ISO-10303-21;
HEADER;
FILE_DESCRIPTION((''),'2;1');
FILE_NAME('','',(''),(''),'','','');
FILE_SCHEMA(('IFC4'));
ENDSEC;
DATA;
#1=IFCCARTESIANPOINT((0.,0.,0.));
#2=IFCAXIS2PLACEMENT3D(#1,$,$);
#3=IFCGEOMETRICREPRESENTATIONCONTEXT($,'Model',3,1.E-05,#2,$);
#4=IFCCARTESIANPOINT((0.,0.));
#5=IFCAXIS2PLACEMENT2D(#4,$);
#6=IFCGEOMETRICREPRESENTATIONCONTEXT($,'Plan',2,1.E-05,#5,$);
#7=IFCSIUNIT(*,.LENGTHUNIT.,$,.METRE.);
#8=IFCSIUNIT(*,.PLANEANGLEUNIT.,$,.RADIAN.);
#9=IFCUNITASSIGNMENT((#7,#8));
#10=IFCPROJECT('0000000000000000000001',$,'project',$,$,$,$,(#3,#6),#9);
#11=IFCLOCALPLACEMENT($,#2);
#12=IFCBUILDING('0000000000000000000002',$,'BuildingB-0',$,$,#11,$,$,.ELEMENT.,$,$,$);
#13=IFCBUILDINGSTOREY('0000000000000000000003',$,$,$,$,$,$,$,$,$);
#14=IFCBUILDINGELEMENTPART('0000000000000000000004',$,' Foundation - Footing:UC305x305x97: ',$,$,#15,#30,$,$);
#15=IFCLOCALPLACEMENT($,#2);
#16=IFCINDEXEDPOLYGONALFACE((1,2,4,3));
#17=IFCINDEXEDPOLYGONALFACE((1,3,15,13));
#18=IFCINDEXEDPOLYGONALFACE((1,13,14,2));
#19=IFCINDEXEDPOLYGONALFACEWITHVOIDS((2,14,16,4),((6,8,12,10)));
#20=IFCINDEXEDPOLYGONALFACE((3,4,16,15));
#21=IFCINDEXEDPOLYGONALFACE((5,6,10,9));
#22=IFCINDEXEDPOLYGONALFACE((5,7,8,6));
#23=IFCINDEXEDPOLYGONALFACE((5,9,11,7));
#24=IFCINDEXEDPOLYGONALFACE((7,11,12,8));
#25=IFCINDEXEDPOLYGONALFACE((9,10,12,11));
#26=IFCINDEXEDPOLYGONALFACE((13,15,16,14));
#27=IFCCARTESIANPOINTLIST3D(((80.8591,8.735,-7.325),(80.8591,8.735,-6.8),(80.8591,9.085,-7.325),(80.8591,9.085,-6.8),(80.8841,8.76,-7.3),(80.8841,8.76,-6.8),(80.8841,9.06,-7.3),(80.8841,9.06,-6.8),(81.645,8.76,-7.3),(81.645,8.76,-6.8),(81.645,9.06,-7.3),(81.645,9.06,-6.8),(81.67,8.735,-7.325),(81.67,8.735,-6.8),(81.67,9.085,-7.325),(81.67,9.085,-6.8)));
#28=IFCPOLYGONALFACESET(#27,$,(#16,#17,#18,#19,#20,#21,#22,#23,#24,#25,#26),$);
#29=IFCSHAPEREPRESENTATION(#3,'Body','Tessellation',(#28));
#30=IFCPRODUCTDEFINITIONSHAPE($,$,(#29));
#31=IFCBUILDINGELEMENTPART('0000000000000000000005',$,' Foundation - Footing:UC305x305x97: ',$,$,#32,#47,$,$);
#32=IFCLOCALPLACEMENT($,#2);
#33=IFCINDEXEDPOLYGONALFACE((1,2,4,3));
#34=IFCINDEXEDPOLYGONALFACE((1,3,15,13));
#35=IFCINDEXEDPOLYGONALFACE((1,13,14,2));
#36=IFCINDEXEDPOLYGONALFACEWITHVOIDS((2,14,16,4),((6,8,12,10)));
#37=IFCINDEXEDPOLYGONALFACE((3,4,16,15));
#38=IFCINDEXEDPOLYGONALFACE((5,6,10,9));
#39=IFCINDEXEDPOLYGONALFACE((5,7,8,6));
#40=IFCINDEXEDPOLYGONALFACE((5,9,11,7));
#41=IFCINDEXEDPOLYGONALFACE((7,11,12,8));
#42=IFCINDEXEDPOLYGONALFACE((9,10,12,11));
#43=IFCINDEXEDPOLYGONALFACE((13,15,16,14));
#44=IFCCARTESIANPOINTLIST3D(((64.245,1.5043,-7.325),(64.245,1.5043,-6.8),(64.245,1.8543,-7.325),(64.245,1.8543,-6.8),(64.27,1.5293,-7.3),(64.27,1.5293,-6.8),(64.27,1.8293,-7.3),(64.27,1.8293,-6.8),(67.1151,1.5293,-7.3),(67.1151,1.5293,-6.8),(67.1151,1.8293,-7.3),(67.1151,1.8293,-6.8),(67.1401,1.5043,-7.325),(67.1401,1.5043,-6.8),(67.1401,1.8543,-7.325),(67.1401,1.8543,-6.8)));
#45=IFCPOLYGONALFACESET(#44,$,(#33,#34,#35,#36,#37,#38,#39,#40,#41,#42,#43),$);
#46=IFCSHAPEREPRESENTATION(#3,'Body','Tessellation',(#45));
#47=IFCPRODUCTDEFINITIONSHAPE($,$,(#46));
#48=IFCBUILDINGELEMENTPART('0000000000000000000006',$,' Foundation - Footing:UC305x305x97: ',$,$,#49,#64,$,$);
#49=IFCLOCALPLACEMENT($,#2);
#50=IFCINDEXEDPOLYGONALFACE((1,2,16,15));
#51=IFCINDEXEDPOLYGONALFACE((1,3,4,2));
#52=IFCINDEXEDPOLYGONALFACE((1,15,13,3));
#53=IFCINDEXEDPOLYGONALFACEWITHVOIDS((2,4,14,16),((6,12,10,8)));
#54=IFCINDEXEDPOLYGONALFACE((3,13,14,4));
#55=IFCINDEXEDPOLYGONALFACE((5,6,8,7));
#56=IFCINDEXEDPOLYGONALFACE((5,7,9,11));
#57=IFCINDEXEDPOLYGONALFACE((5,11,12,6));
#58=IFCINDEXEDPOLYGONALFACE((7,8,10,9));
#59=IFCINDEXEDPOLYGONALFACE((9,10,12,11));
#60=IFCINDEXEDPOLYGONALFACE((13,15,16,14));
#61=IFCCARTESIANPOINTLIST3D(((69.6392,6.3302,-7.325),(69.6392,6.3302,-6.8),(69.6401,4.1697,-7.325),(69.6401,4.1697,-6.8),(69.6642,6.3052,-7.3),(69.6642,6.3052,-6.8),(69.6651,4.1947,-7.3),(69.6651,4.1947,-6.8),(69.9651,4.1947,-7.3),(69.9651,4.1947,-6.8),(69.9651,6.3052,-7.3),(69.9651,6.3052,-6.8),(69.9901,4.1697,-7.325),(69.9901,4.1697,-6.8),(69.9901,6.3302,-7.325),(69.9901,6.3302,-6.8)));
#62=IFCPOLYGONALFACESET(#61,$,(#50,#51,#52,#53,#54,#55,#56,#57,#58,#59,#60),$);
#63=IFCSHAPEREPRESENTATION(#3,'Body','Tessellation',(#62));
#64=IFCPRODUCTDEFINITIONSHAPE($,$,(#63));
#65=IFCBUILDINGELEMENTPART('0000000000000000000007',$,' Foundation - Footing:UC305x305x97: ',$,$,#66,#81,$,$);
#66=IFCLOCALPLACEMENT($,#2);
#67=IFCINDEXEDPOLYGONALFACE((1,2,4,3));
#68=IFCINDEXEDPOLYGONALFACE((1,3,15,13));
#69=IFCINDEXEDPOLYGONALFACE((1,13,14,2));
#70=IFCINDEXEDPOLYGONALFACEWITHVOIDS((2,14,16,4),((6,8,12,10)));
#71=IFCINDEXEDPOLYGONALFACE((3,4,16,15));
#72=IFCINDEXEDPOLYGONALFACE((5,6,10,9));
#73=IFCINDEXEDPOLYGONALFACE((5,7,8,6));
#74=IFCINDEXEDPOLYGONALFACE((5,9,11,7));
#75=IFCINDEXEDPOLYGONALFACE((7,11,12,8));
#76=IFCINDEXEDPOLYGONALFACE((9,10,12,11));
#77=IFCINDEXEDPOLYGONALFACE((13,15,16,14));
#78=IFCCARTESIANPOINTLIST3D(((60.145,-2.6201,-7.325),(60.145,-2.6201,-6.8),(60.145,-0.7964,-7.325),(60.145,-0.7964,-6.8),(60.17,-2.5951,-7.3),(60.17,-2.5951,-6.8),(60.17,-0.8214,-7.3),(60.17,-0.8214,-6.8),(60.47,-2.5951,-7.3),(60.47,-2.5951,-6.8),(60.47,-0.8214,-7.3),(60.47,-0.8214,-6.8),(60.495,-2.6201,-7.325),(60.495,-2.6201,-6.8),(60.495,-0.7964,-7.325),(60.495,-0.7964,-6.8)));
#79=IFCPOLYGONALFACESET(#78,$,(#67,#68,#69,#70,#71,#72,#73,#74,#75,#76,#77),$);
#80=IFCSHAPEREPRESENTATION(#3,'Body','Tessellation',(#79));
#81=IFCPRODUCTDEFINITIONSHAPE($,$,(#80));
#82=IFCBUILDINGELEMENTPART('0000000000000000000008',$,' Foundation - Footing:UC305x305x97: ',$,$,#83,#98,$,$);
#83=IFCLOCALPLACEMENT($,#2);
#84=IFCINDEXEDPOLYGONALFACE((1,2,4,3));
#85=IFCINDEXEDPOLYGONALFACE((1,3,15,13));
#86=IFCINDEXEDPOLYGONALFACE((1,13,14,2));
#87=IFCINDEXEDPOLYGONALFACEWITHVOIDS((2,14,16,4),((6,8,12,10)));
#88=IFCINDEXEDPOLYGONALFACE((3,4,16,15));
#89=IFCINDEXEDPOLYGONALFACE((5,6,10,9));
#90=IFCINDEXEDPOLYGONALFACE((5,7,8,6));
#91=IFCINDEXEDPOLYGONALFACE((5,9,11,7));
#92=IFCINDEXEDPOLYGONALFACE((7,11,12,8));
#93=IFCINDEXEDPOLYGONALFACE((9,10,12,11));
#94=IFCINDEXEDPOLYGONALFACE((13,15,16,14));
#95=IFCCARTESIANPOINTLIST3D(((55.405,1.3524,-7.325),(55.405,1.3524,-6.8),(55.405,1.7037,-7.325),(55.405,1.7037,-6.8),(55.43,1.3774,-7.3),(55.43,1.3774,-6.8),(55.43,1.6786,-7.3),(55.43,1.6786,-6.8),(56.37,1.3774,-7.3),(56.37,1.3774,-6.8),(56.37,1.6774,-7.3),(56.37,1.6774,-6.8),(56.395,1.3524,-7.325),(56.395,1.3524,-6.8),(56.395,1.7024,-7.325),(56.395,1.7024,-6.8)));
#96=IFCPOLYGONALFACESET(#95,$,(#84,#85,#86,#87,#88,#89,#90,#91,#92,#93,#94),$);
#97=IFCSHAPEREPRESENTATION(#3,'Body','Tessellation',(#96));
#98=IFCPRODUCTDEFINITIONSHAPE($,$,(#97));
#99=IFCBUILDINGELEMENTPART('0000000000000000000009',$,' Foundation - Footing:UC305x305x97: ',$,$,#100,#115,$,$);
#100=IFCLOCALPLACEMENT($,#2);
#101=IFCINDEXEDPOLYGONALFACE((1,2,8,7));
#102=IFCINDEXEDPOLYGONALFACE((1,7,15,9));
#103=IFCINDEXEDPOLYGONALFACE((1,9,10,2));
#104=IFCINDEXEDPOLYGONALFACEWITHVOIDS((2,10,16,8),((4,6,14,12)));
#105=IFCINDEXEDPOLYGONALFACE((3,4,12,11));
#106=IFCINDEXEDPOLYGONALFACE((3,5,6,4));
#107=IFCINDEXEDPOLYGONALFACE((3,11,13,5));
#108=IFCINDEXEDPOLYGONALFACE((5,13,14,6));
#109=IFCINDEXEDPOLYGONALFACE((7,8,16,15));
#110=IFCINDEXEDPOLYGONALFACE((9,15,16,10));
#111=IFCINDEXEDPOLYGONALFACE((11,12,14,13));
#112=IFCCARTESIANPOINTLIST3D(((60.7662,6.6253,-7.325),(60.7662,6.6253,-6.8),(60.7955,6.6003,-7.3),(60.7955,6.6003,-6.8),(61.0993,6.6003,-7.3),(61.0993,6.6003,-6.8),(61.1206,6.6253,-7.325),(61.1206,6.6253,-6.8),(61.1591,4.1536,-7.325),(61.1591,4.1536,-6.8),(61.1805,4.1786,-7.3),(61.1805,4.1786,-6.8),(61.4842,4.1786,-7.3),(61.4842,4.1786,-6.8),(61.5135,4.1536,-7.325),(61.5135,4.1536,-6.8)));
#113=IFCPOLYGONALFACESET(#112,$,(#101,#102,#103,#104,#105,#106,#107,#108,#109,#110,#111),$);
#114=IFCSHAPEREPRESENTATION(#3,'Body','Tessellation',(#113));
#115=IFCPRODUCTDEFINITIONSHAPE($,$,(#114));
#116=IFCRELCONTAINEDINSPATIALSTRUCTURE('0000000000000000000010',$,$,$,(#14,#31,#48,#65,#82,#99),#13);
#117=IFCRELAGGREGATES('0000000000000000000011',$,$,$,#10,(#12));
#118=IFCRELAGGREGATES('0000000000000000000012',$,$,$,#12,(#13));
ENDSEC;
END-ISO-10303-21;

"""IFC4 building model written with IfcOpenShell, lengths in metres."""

from ifc_helpers import new_model, si_unit, origin, origin_2d, place, context, project, spatial, polyline, outline, extrude, element, save


model = new_model("IFC4")

# Units and contexts
model_context = context("Model", 3, precision=1e-05, world=origin())
plan_context = context("Plan", 2, precision=1e-05, world=origin_2d())
ifc_project = project(units=[si_unit("LENGTHUNIT", "METRE"), si_unit("PLANEANGLEUNIT", "RADIAN")], contexts=[model_context, plan_context])

# Building, storey
building_placement = place(None, origin())
building = spatial("IfcBuilding", under=ifc_project, at=building_placement, Name="BuildingB-0", CompositionType="ELEMENT")
storey = spatial("IfcBuildingStorey", under=building)

# Building element parts, openings
building_element_part_1 = element("IfcBuildingElementPart", 1, inside=storey, Name=" Foundation - Footing:UC305x305x97: ", context=model_context, shape_type="SweptSolid", body=[
    extrude(outline(polyline([(81.67, 8.735, -7.325), (80.8591, 8.735, -7.325), (80.8591, 9.085, -7.325), (81.67, 9.085, -7.325), (81.67, 8.735, -7.325)])), None, (0.0, 0.0, 1.0), 0.525),
])
element("IfcOpeningElement", 2, inside=storey, cuts=building_element_part_1, context=model_context, shape_type="SweptSolid", body=[
    extrude(outline(polyline([(81.645, 8.76, -7.3), (80.8841, 8.76, -7.3), (80.8841, 9.06, -7.3), (81.645, 9.06, -7.3), (81.645, 8.76, -7.3)])), None, (0.0, 0.0, 1.0), 0.5),
])
building_element_part_2 = element("IfcBuildingElementPart", 3, inside=storey, Name=" Foundation - Footing:UC305x305x97: ", context=model_context, shape_type="SweptSolid", body=[
    extrude(outline(polyline([(67.1401, 1.5043, -7.325), (67.1401, 1.8543, -7.325), (64.245, 1.8543, -7.325), (64.245, 1.5043, -7.325), (67.1401, 1.5043, -7.325)])), None, (0.0, 0.0, 1.0), 0.525),
])
element("IfcOpeningElement", 4, inside=storey, cuts=building_element_part_2, context=model_context, shape_type="SweptSolid", body=[
    extrude(outline(polyline([(67.1151, 1.5293, -7.3), (67.1151, 1.8293, -7.3), (64.27, 1.8293, -7.3), (64.27, 1.5293, -7.3), (67.1151, 1.5293, -7.3)])), None, (0.0, 0.0, 1.0), 0.5),
])
building_element_part_3 = element("IfcBuildingElementPart", 5, inside=storey, Name=" Foundation - Footing:UC305x305x97: ", context=model_context, shape_type="SweptSolid", body=[
    extrude(outline(polyline([(69.9901, 4.1697, -7.325), (69.6401, 4.1697, -7.325), (69.6392, 6.3302, -7.325), (69.9901, 6.3302, -7.325), (69.9901, 4.1697, -7.325)])), None, (0.0, 0.0, 1.0), 0.525),
])
element("IfcOpeningElement", 6, inside=storey, cuts=building_element_part_3, context=model_context, shape_type="SweptSolid", body=[
    extrude(outline(polyline([(69.9651, 4.1947, -7.3), (69.6651, 4.1947, -7.3), (69.6642, 6.3052, -7.3), (69.9651, 6.3052, -7.3), (69.9651, 4.1947, -7.3)])), None, (0.0, 0.0, 1.0), 0.5),
])
building_element_part_4 = element("IfcBuildingElementPart", 7, inside=storey, Name=" Foundation - Footing:UC305x305x97: ", context=model_context, shape_type="SweptSolid", body=[
    extrude(outline(polyline([(60.495, -2.6201, -7.325), (60.145, -2.6201, -7.325), (60.145, -0.7964, -7.325), (60.495, -0.7964, -7.325), (60.495, -2.6201, -7.325)])), None, (0.0, 0.0, 1.0), 0.525),
])
element("IfcOpeningElement", 8, inside=storey, cuts=building_element_part_4, context=model_context, shape_type="SweptSolid", body=[
    extrude(outline(polyline([(60.47, -2.5951, -7.3), (60.17, -2.5951, -7.3), (60.17, -0.8214, -7.3), (60.47, -0.8214, -7.3), (60.47, -2.5951, -7.3)])), None, (0.0, 0.0, 1.0), 0.5),
])
building_element_part_5 = element("IfcBuildingElementPart", 9, inside=storey, Name=" Foundation - Footing:UC305x305x97: ", context=model_context, shape_type="SweptSolid", body=[
    extrude(outline(polyline([(56.395, 1.3524, -7.325), (56.395, 1.7024, -7.325), (55.405, 1.7037, -7.325), (55.405, 1.3524, -7.325), (56.395, 1.3524, -7.325)])), None, (0.0, 0.0, 1.0), 0.525),
])
element("IfcOpeningElement", 10, inside=storey, cuts=building_element_part_5, context=model_context, shape_type="SweptSolid", body=[
    extrude(outline(polyline([(56.37, 1.3774, -7.3), (56.37, 1.6774, -7.3), (55.43, 1.6786, -7.3), (55.43, 1.3774, -7.3), (56.37, 1.3774, -7.3)])), None, (0.0, 0.0, 1.0), 0.5),
])
building_element_part_6 = element("IfcBuildingElementPart", 11, inside=storey, Name=" Foundation - Footing:UC305x305x97: ", context=model_context, shape_type="SweptSolid", body=[
    extrude(outline(polyline([(61.5135, 4.1536, -7.325), (61.1206, 6.6253, -7.325), (60.7662, 6.6253, -7.325), (61.1591, 4.1536, -7.325), (61.5135, 4.1536, -7.325)])), None, (0.0, 0.0, 1.0), 0.525),
])
element("IfcOpeningElement", 12, inside=storey, cuts=building_element_part_6, context=model_context, shape_type="SweptSolid", body=[
    extrude(outline(polyline([(61.4842, 4.1786, -7.3), (61.0993, 6.6003, -7.3), (60.7955, 6.6003, -7.3), (61.1805, 4.1786, -7.3), (61.4842, 4.1786, -7.3)])), None, (0.0, 0.0, 1.0), 0.5),
])

save(model, "model.ifc")
